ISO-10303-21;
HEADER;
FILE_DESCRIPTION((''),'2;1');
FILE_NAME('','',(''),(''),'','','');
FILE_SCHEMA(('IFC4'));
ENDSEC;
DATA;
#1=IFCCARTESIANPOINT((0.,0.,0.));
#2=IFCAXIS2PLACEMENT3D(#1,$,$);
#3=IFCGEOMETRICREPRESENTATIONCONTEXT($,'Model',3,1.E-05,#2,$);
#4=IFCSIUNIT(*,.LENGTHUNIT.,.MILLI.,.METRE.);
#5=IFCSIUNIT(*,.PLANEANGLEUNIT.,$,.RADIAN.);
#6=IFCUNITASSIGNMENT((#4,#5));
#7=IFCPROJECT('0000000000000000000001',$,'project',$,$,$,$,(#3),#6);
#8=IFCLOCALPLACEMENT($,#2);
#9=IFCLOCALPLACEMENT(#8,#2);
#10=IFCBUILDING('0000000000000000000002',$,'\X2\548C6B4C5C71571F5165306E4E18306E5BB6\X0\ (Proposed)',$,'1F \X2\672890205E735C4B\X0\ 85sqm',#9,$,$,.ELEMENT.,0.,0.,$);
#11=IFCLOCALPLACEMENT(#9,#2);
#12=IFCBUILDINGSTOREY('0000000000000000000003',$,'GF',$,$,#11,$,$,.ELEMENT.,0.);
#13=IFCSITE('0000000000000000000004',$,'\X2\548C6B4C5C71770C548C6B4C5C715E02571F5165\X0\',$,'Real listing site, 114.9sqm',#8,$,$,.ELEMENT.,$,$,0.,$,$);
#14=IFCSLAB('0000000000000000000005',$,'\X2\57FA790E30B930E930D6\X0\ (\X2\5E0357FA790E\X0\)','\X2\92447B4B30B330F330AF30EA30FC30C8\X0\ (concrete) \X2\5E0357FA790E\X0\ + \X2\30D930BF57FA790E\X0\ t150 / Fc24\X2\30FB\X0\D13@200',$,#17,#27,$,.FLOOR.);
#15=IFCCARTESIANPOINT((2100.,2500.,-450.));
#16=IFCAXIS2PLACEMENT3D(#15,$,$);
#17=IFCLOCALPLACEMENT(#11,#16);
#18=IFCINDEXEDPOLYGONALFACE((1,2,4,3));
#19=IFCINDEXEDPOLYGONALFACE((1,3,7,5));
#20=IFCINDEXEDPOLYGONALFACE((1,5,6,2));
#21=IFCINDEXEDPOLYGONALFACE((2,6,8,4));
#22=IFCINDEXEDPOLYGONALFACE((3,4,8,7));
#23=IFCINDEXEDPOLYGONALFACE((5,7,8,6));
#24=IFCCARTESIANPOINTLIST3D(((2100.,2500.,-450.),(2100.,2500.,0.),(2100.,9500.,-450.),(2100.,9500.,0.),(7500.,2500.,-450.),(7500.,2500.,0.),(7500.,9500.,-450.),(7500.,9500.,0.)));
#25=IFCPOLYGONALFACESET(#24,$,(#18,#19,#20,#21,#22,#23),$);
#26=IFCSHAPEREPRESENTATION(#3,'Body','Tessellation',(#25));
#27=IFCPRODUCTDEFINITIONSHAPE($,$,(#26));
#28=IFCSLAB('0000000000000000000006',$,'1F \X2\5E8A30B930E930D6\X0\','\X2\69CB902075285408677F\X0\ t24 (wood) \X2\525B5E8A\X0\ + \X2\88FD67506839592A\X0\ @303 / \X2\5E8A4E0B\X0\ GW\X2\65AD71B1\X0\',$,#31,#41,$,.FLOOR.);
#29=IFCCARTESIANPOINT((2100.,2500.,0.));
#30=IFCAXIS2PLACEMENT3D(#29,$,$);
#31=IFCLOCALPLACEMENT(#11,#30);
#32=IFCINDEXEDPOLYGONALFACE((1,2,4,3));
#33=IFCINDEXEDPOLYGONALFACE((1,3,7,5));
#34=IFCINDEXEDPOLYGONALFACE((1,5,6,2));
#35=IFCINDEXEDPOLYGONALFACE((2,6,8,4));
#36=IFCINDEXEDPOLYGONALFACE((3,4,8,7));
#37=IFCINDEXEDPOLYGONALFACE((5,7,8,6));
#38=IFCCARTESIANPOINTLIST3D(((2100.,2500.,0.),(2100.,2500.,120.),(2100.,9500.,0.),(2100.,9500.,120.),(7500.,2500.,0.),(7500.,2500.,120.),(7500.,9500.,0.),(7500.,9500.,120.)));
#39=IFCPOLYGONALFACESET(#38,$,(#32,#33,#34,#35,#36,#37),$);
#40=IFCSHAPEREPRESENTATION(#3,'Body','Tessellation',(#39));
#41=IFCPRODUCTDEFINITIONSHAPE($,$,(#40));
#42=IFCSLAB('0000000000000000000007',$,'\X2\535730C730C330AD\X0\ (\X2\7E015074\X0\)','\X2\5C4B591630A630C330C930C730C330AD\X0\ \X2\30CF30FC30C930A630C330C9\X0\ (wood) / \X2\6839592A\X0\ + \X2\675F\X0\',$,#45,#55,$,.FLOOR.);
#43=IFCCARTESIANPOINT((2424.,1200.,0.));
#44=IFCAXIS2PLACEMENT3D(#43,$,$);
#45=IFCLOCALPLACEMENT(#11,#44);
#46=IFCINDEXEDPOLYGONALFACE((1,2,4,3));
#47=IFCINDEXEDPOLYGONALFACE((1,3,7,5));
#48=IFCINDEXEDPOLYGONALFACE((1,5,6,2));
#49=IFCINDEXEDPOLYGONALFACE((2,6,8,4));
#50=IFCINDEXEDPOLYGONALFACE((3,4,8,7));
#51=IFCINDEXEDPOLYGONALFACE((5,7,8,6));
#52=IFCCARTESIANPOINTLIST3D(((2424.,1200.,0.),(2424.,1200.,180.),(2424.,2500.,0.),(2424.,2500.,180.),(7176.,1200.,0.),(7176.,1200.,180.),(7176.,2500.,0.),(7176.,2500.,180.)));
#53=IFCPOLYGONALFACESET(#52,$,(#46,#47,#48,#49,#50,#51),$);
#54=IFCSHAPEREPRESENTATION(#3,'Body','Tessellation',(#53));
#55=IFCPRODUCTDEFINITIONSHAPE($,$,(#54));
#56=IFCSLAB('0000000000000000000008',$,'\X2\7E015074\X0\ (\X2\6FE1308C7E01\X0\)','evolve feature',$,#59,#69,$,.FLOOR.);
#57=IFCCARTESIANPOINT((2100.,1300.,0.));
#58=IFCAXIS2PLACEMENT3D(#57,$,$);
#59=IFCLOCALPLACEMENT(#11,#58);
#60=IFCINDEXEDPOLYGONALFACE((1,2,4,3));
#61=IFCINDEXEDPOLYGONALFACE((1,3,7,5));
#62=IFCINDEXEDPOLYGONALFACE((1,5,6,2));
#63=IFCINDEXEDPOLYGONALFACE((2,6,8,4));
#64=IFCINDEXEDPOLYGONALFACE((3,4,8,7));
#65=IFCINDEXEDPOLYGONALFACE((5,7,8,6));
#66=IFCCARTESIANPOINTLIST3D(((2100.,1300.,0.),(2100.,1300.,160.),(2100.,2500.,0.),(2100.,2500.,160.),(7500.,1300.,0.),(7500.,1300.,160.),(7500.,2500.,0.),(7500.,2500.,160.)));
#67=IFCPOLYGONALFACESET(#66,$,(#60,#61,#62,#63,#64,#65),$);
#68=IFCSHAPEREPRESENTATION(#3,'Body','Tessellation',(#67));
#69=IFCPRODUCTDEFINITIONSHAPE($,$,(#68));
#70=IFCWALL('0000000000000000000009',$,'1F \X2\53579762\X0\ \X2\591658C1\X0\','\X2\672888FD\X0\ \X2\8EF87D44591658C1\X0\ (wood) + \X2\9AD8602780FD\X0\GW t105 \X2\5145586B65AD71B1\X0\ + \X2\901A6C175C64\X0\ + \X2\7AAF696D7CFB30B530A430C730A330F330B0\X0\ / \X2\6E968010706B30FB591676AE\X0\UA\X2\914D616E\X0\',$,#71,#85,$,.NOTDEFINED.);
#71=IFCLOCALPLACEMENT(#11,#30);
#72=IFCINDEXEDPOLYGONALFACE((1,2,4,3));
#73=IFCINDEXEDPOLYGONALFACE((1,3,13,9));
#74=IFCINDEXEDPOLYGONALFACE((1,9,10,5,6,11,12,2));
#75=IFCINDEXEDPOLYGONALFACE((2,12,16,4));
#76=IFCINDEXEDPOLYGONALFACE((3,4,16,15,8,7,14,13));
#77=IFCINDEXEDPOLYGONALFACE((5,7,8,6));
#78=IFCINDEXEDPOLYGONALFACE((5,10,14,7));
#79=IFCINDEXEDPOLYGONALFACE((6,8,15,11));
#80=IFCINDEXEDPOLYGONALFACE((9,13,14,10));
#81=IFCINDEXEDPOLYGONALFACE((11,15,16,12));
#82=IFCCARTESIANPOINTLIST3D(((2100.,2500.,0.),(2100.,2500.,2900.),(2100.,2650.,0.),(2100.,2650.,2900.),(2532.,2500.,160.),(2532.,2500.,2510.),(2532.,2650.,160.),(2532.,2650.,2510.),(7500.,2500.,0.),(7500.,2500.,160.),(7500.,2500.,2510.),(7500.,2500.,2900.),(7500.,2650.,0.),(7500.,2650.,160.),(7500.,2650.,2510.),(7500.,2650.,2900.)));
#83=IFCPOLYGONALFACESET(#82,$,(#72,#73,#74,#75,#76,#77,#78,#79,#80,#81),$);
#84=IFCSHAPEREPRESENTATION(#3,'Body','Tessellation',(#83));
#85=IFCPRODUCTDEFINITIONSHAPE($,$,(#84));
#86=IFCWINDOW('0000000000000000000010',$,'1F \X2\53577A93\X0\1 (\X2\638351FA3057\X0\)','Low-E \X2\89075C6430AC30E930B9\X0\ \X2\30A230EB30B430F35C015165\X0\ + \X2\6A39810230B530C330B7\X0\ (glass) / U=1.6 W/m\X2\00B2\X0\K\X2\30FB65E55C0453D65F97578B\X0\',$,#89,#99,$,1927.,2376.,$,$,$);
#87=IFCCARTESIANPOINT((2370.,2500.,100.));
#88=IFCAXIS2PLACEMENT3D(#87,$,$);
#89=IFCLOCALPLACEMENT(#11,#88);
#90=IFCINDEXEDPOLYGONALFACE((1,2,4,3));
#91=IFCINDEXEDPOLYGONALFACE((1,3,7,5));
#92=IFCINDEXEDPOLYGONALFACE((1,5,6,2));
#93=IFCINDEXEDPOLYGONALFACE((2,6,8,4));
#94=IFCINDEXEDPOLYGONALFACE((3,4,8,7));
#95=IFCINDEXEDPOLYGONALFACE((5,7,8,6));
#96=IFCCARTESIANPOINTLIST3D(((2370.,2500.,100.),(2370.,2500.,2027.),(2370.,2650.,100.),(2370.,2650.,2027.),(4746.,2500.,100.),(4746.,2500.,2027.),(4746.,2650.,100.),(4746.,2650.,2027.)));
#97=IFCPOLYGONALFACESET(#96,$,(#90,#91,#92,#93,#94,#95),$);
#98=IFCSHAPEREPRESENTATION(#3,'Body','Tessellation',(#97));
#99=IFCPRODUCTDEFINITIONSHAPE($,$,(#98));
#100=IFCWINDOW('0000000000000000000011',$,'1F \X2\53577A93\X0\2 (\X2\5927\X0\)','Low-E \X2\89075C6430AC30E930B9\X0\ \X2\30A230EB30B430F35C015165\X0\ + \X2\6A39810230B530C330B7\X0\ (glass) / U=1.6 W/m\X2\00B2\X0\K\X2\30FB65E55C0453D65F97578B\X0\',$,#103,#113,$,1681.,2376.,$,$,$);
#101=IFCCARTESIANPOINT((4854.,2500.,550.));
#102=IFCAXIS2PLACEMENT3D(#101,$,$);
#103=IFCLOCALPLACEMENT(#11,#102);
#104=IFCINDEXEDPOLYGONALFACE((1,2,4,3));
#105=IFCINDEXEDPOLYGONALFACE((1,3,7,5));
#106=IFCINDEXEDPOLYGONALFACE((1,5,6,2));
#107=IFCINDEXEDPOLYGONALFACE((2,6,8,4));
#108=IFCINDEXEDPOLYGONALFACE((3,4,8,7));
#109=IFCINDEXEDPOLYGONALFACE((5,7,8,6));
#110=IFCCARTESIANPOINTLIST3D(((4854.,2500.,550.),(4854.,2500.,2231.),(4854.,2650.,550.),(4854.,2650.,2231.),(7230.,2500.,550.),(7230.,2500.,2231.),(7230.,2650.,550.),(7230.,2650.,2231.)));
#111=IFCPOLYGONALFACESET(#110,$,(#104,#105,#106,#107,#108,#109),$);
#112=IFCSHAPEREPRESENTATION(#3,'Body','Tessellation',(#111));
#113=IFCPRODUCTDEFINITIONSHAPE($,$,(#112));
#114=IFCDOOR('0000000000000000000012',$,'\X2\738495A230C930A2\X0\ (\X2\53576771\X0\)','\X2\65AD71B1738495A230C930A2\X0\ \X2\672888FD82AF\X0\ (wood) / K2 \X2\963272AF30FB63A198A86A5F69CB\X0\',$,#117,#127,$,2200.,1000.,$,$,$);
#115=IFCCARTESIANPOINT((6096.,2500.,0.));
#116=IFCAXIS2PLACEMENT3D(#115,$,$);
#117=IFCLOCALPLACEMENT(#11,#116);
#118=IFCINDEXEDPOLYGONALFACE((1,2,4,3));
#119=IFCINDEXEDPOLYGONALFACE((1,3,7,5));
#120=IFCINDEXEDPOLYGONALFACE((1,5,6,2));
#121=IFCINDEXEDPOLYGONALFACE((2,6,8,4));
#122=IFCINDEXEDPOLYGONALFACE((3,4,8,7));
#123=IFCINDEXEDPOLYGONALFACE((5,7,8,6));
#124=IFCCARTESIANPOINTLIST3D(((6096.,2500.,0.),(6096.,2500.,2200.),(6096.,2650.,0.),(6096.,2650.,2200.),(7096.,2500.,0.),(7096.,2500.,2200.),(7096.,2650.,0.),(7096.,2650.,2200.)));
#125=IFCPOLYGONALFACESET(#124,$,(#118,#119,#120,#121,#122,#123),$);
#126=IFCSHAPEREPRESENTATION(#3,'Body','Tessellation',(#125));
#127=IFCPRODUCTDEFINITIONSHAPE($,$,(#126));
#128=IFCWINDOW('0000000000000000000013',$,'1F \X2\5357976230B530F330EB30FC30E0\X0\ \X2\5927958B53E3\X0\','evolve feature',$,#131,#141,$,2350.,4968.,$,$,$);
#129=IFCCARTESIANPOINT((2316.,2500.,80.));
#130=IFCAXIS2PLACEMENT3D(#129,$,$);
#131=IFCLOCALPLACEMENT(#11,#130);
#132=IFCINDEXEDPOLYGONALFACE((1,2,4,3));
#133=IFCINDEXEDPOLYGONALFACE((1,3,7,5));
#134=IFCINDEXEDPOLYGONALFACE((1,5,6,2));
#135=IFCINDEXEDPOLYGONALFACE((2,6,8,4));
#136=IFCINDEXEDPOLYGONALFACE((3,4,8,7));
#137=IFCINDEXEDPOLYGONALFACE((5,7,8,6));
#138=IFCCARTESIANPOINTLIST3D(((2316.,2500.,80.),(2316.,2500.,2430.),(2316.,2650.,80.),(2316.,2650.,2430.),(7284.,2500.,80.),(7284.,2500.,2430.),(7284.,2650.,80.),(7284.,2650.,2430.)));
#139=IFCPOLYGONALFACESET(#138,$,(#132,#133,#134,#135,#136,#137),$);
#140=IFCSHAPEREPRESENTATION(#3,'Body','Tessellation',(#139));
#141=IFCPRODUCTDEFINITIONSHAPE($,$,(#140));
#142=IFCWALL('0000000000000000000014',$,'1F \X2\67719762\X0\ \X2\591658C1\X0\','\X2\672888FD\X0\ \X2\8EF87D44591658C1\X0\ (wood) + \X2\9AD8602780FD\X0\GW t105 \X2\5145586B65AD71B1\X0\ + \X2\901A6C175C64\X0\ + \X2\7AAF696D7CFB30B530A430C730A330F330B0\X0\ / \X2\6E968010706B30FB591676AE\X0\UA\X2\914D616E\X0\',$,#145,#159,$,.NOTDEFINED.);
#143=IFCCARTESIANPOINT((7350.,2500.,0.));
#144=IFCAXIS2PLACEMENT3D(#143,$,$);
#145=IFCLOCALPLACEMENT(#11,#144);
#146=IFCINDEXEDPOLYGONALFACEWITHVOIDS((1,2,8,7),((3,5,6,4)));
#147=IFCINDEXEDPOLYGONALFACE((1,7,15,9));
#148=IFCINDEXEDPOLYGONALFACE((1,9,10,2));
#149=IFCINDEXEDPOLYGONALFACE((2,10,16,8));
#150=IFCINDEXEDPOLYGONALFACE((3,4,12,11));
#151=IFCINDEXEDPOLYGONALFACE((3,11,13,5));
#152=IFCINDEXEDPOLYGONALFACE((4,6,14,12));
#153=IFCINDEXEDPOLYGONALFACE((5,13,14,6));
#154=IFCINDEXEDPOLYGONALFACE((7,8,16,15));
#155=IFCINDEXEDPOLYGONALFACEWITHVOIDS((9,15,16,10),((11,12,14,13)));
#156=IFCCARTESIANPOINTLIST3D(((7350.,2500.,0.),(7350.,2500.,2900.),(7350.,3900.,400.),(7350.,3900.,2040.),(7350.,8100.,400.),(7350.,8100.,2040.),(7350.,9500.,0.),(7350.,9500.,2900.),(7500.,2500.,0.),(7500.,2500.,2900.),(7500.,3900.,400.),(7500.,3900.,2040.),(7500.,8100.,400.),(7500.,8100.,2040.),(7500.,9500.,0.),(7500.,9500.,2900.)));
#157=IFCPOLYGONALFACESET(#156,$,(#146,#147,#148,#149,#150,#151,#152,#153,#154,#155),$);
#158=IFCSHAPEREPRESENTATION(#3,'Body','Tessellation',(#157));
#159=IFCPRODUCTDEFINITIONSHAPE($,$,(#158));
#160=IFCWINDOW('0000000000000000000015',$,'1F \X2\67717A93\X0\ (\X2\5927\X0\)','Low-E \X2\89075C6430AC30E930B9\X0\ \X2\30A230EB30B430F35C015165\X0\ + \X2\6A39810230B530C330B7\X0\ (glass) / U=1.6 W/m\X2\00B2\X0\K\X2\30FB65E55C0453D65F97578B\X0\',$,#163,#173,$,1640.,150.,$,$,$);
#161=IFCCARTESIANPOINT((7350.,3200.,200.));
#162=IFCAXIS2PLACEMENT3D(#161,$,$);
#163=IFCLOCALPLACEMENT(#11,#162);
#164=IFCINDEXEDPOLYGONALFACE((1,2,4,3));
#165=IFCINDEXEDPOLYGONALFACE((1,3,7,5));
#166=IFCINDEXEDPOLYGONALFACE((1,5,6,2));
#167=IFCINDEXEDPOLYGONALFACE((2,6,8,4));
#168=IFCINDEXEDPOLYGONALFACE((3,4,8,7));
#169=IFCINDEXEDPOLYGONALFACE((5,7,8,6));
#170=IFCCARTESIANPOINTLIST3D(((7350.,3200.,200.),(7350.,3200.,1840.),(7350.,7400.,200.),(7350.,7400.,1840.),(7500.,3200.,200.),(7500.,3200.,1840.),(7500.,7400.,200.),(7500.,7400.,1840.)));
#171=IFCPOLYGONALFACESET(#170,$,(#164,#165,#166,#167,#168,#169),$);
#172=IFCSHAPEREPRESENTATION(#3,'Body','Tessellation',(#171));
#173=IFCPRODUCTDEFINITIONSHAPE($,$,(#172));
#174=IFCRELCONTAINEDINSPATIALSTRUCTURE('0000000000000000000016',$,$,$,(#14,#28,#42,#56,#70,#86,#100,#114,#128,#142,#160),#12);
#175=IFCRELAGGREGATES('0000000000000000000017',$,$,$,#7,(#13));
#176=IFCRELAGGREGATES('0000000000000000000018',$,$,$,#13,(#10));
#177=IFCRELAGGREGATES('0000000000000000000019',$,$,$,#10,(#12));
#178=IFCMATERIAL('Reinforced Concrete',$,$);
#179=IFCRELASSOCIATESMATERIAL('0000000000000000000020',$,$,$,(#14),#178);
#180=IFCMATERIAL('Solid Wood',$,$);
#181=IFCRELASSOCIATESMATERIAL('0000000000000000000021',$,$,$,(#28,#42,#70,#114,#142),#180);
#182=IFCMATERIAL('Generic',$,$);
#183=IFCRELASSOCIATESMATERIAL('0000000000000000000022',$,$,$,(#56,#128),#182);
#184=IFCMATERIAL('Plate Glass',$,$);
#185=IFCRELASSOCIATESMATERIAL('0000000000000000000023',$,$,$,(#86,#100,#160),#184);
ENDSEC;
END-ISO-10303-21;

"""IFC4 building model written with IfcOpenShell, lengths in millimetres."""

from ifc_helpers import new_model, si_unit, frame, frame_2d, origin, place, context, project, spatial, rectangle, extrude, material, element, fill, save


model = new_model("IFC4")

# Units and contexts
model_context = context("Model", 3, precision=1e-05, world=origin())
ifc_project = project(units=[si_unit("LENGTHUNIT", "METRE", prefix="MILLI"), si_unit("PLANEANGLEUNIT", "RADIAN")], contexts=[model_context])

# Site, building, storey
site_placement = place(None, origin())
site = spatial("IfcSite", under=ifc_project, at=site_placement, Name="和歌山県和歌山市土入", ObjectType="Real listing site, 114.9sqm", CompositionType="ELEMENT", RefElevation=0.0)
building_placement = place(site_placement, origin())
building = spatial("IfcBuilding", under=site, at=building_placement, Name="和歌山土入の丘の家 (Proposed)", ObjectType="1F 木造平屋 85sqm", CompositionType="ELEMENT", ElevationOfRefHeight=0.0, ElevationOfTerrain=0.0)
storey_placement = place(building_placement, origin())
storey = spatial("IfcBuildingStorey", under=building, at=storey_placement, Name="GF", CompositionType="ELEMENT", Elevation=0.0)

# Slabs
ifc_material_1 = material(Name="Reinforced Concrete")
slab_1_placement = place(storey_placement, frame((2100.0, 2500.0, -450.0)))
element("IfcSlab", 1, at=slab_1_placement, inside=storey, material=ifc_material_1, Name="基礎スラブ (布基礎)", Description="鉄筋コンクリート (concrete) 布基礎 + ベタ基礎 t150 / Fc24・D13@200", PredefinedType="FLOOR", context=model_context, shape_type="SweptSolid", body=[
    extrude(rectangle(XDim=5400.0, YDim=7000.0, at=frame_2d((2700.0, 3500.0))), frame((2100.0, 2500.0, -450.0)), (0.0, 0.0, 1.0), 450.0),
])
ifc_material_2 = material(Name="Solid Wood")
slab_2_placement = place(storey_placement, frame((2100.0, 2500.0, 0.0)))
element("IfcSlab", 2, at=slab_2_placement, inside=storey, material=ifc_material_2, Name="1F 床スラブ", Description="構造用合板 t24 (wood) 剛床 + 製材根太 @303 / 床下 GW断熱", PredefinedType="FLOOR", context=model_context, shape_type="SweptSolid", body=[
    extrude(rectangle(XDim=5400.0, YDim=7000.0, at=frame_2d((2700.0, 3500.0))), frame((2100.0, 2500.0, 0.0)), (0.0, 0.0, 1.0), 120.0),
])
slab_3_placement = place(storey_placement, frame((2424.0, 1200.0, 0.0)))
element("IfcSlab", 3, at=slab_3_placement, inside=storey, material=ifc_material_2, Name="南デッキ (縁側)", Description="屋外ウッドデッキ ハードウッド (wood) / 根太 + 束", PredefinedType="FLOOR", context=model_context, shape_type="SweptSolid", body=[
    extrude(rectangle(XDim=4752.0, YDim=1300.0, at=frame_2d((2376.0, 650.0))), frame((2424.0, 1200.0, 0.0)), (0.0, 0.0, 1.0), 180.0),
])
ifc_material_3 = material(Name="Generic")
slab_4_placement = place(storey_placement, frame((2100.0, 1300.0, 0.0)))
element("IfcSlab", 4, at=slab_4_placement, inside=storey, material=ifc_material_3, Name="縁側 (濡れ縁)", Description="evolve feature", PredefinedType="FLOOR", context=model_context, shape_type="SweptSolid", body=[
    extrude(rectangle(XDim=5400.0, YDim=1200.0, at=frame_2d((2700.0, 600.0))), frame((2100.0, 1300.0, 0.0)), (0.0, 0.0, 1.0), 160.0),
])

# Wall, openings, windows, door
wall_1_placement = place(storey_placement, frame((2100.0, 2500.0, 0.0)))
wall_1 = element("IfcWall", 5, at=wall_1_placement, inside=storey, material=ifc_material_2, Name="1F 南面 外壁", Description="木製 軸組外壁 (wood) + 高性能GW t105 充填断熱 + 通気層 + 窯業系サイディング / 準耐火・外皮UA配慮", PredefinedType="NOTDEFINED", context=model_context, shape_type="SweptSolid", body=[
    extrude(rectangle(XDim=5400.0, YDim=150.0, at=frame_2d((2700.0, 75.0))), frame((2100.0, 2500.0, 0.0)), (0.0, 0.0, 1.0), 2900.0),
])
opening_1_placement = place(storey_placement, frame((2370.0, 2500.0, 100.0)))
opening_1 = element("IfcOpeningElement", 6, at=opening_1_placement, cuts=wall_1, PredefinedType="NOTDEFINED", context=model_context, shape_type="SweptSolid", body=[
    extrude(rectangle(XDim=2376.0, YDim=150.0, at=frame_2d((1188.0, 75.0))), frame((2370.0, 2500.0, 100.0)), (0.0, 0.0, 1.0), 1927.0),
])
opening_2_placement = place(storey_placement, frame((4854.0, 2500.0, 550.0)))
opening_2 = element("IfcOpeningElement", 7, at=opening_2_placement, cuts=wall_1, PredefinedType="NOTDEFINED", context=model_context, shape_type="SweptSolid", body=[
    extrude(rectangle(XDim=2376.0, YDim=150.0, at=frame_2d((1188.0, 75.0))), frame((4854.0, 2500.0, 550.0)), (0.0, 0.0, 1.0), 1681.0),
])
opening_3_placement = place(storey_placement, frame((6096.0, 2500.0, 0.0)))
opening_3 = element("IfcOpeningElement", 8, at=opening_3_placement, cuts=wall_1, PredefinedType="NOTDEFINED", context=model_context, shape_type="SweptSolid", body=[
    extrude(rectangle(XDim=1000.0, YDim=150.0, at=frame_2d((500.0, 75.0))), frame((6096.0, 2500.0, 0.0)), (0.0, 0.0, 1.0), 2200.0),
])
opening_4_placement = place(storey_placement, frame((2316.0, 2500.0, 80.0)))
opening_4 = element("IfcOpeningElement", 9, at=opening_4_placement, cuts=wall_1, PredefinedType="NOTDEFINED", context=model_context, shape_type="SweptSolid", body=[
    extrude(rectangle(XDim=4968.0, YDim=150.0, at=frame_2d((2484.0, 75.0))), frame((2316.0, 2500.0, 80.0)), (0.0, 0.0, 1.0), 2350.0),
])
ifc_material_4 = material(Name="Plate Glass")
window_1_placement = place(storey_placement, frame((2370.0, 2500.0, 100.0)))
window_1 = element("IfcWindow", 10, at=window_1_placement, inside=storey, material=ifc_material_4, Name="1F 南窓1 (掃出し)", Description="Low-E 複層ガラス アルゴン封入 + 樹脂サッシ (glass) / U=1.6 W/m²K・日射取得型", OverallHeight=1927.0, OverallWidth=2376.0, context=model_context, shape_type="SweptSolid", body=[
    extrude(rectangle(XDim=2376.0, YDim=150.0, at=frame_2d((1188.0, 75.0))), frame((2370.0, 2500.0, 100.0)), (0.0, 0.0, 1.0), 1927.0),
])
fill(opening_1, window_1)
window_2_placement = place(storey_placement, frame((4854.0, 2500.0, 550.0)))
window_2 = element("IfcWindow", 11, at=window_2_placement, inside=storey, material=ifc_material_4, Name="1F 南窓2 (大)", Description="Low-E 複層ガラス アルゴン封入 + 樹脂サッシ (glass) / U=1.6 W/m²K・日射取得型", OverallHeight=1681.0, OverallWidth=2376.0, context=model_context, shape_type="SweptSolid", body=[
    extrude(rectangle(XDim=2376.0, YDim=150.0, at=frame_2d((1188.0, 75.0))), frame((4854.0, 2500.0, 550.0)), (0.0, 0.0, 1.0), 1681.0),
])
fill(opening_2, window_2)
door_placement = place(storey_placement, frame((6096.0, 2500.0, 0.0)))
door = element("IfcDoor", 12, at=door_placement, inside=storey, material=ifc_material_2, Name="玄関ドア (南東)", Description="断熱玄関ドア 木製芯 (wood) / K2 防犯・採風機構", OverallHeight=2200.0, OverallWidth=1000.0, context=model_context, shape_type="SweptSolid", body=[
    extrude(rectangle(XDim=1000.0, YDim=150.0, at=frame_2d((500.0, 75.0))), frame((6096.0, 2500.0, 0.0)), (0.0, 0.0, 1.0), 2200.0),
])
fill(opening_3, door)
window_3_placement = place(storey_placement, frame((2316.0, 2500.0, 80.0)))
window_3 = element("IfcWindow", 13, at=window_3_placement, inside=storey, material=ifc_material_3, Name="1F 南面サンルーム 大開口", Description="evolve feature", OverallHeight=2350.0, OverallWidth=4968.0, context=model_context, shape_type="SweptSolid", body=[
    extrude(rectangle(XDim=4968.0, YDim=150.0, at=frame_2d((2484.0, 75.0))), frame((2316.0, 2500.0, 80.0)), (0.0, 0.0, 1.0), 2350.0),
])
fill(opening_4, window_3)

# Wall, opening, window
wall_2_placement = place(storey_placement, frame((7350.0, 2500.0, 0.0)))
wall_2 = element("IfcWall", 14, at=wall_2_placement, inside=storey, material=ifc_material_2, Name="1F 東面 外壁", Description="木製 軸組外壁 (wood) + 高性能GW t105 充填断熱 + 通気層 + 窯業系サイディング / 準耐火・外皮UA配慮", PredefinedType="NOTDEFINED", context=model_context, shape_type="SweptSolid", body=[
    extrude(rectangle(XDim=150.0, YDim=7000.0, at=frame_2d((75.0, 3500.0))), frame((7350.0, 2500.0, 0.0)), (0.0, 0.0, 1.0), 2900.0),
])
opening_5_placement = place(storey_placement, frame((7350.0, 3200.0, 200.0)))
opening_5 = element("IfcOpeningElement", 15, at=opening_5_placement, cuts=wall_2, PredefinedType="NOTDEFINED", context=model_context, shape_type="SweptSolid", body=[
    extrude(rectangle(XDim=150.0, YDim=4200.0, at=frame_2d((75.0, 2100.0))), frame((7350.0, 3200.0, 200.0)), (0.0, 0.0, 1.0), 1640.0),
])
window_4_placement = place(storey_placement, frame((7350.0, 3200.0, 200.0)))
window_4 = element("IfcWindow", 16, at=window_4_placement, inside=storey, material=ifc_material_4, Name="1F 東窓 (大)", Description="Low-E 複層ガラス アルゴン封入 + 樹脂サッシ (glass) / U=1.6 W/m²K・日射取得型", OverallHeight=1640.0, OverallWidth=150.0, context=model_context, shape_type="SweptSolid", body=[
    extrude(rectangle(XDim=150.0, YDim=4200.0, at=frame_2d((75.0, 2100.0))), frame((7350.0, 3200.0, 200.0)), (0.0, 0.0, 1.0), 1640.0),
])
fill(opening_5, window_4)

save(model, "model.ifc")
